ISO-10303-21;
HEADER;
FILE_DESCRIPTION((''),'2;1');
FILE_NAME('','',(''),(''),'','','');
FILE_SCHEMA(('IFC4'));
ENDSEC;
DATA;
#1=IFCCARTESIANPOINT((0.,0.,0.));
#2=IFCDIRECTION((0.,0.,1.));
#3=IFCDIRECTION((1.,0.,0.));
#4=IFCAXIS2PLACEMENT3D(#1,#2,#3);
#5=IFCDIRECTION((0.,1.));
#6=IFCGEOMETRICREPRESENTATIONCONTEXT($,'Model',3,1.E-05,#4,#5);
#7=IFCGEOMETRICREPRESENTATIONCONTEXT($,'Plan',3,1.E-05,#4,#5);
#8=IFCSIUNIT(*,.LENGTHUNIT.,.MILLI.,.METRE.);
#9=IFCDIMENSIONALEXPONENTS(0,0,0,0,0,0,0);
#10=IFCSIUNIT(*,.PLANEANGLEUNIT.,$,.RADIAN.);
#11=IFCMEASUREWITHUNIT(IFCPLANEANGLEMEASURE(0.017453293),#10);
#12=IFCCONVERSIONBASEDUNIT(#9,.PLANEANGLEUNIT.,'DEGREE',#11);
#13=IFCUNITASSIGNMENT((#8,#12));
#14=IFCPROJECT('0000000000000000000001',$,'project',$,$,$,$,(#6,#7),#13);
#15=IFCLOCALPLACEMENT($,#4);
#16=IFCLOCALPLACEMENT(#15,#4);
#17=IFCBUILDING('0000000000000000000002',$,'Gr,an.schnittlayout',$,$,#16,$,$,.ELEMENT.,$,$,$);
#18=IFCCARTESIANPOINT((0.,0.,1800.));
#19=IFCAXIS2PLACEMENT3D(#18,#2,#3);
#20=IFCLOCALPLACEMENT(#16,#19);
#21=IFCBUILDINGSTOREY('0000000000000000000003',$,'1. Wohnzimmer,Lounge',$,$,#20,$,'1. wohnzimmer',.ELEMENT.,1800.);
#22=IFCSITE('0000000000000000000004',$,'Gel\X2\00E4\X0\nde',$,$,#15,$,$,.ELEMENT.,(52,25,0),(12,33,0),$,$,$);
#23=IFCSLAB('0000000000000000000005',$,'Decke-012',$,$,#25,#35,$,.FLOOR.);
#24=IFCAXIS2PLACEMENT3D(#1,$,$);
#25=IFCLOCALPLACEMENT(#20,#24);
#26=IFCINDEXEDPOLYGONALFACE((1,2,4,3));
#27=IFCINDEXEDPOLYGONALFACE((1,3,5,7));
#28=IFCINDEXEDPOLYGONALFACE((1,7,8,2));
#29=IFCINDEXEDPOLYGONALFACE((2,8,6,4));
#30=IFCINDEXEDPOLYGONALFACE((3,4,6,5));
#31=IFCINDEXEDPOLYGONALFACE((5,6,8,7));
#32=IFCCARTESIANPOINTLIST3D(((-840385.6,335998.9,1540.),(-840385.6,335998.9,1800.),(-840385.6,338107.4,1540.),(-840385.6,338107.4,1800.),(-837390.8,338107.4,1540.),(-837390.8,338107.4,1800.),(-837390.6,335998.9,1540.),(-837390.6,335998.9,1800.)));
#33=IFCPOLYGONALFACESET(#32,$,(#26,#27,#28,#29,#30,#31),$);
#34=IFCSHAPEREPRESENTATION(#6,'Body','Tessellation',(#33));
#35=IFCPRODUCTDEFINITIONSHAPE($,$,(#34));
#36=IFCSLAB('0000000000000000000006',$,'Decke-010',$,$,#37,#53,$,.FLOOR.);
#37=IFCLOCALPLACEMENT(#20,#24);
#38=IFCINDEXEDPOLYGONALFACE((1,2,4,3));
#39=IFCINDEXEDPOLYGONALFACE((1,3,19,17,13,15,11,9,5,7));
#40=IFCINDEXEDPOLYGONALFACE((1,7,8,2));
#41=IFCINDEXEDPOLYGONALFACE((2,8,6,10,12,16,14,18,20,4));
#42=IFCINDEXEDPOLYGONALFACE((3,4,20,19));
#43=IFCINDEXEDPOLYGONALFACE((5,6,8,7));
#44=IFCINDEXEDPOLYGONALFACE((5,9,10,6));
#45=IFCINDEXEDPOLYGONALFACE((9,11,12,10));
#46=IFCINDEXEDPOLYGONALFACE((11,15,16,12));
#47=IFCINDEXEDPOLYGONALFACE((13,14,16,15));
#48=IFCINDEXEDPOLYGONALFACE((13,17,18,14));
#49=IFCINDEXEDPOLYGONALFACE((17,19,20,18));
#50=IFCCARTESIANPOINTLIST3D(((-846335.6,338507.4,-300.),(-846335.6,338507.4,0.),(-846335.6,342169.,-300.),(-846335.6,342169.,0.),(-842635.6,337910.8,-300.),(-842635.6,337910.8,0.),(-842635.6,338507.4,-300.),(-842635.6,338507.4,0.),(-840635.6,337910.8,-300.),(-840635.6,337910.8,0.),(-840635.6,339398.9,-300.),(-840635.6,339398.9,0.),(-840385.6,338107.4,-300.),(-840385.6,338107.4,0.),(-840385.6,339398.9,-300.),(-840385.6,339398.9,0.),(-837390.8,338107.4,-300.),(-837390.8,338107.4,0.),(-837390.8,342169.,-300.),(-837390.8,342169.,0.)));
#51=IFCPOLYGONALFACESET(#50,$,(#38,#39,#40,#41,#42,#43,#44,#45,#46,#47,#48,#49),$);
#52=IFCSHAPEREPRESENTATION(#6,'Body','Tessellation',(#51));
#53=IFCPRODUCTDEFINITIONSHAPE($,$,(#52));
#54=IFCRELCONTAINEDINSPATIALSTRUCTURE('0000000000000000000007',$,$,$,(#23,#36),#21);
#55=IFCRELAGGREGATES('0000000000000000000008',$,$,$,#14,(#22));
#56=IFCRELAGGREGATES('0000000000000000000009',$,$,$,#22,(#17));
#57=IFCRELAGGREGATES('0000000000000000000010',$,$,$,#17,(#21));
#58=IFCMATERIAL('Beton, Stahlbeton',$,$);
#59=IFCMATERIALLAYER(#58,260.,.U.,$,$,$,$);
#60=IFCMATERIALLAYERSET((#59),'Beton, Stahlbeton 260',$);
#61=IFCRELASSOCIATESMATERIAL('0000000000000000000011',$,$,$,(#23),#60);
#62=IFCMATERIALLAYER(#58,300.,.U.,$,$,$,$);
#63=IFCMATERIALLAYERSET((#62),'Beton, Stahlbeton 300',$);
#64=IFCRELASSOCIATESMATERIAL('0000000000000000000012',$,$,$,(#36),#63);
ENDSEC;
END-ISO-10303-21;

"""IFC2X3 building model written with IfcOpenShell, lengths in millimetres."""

from ifc_helpers import new_model, entity, si_unit, converted_unit, direction, frame, origin_with_axes, place, context, project, spatial, polyline, outline, extrude, material, layer, layer_set, layer_usage, element, save


model = new_model("IFC2X3")

# Units and contexts
model_context = context("Model", 3, precision=1e-05, world=origin_with_axes(), true_north=direction((0.0, 1.0)))
plan_context = context("Plan", 3, precision=1e-05, world=origin_with_axes(), true_north=direction((0.0, 1.0)))
ifc_project = project(units=[si_unit("LENGTHUNIT", "METRE", prefix="MILLI"), converted_unit("PLANEANGLEUNIT", "DEGREE", entity("IfcPlaneAngleMeasure", 0.017453293), si_unit("PLANEANGLEUNIT", "RADIAN"), dimensions=[0, 0, 0, 0, 0, 0, 0])], contexts=[model_context, plan_context])

# Site, building, storey
site_placement = place(None, origin_with_axes())
site = spatial("IfcSite", under=ifc_project, at=site_placement, Name="Gelände", CompositionType="ELEMENT", RefLatitude=(52, 25, 0), RefLongitude=(12, 33, 0))
building_placement = place(site_placement, origin_with_axes())
building = spatial("IfcBuilding", under=site, at=building_placement, Name="Gr,an.schnittlayout", CompositionType="ELEMENT")
storey_placement = place(building_placement, frame((0.0, 0.0, 1800.0), z_axis=(0.0, 0.0, 1.0), x_axis=(1.0, 0.0, 0.0)))
storey = spatial("IfcBuildingStorey", under=building, at=storey_placement, Name="1. Wohnzimmer,Lounge", LongName="1. wohnzimmer", CompositionType="ELEMENT", Elevation=1800.0)

# Slabs
ifc_material = material(Name="Beton, Stahlbeton")
ifc_layer_1 = layer(ifc_material, 260.0, ventilated="UNKNOWN")
ifc_layer_set_1 = layer_set([ifc_layer_1], Name="Beton, Stahlbeton 260")
ifc_layer_usage_1 = layer_usage(ifc_layer_set_1, "AXIS3", "NEGATIVE", 260.0)
slab_1_placement = place(storey_placement, frame((-840385.7, 338107.4, 1540.0), z_axis=(0.0, 0.0, 1.0), x_axis=(1.0, 0.0, 0.0)))
element("IfcSlab", 1, at=slab_1_placement, inside=storey, material=ifc_layer_usage_1, Name="Decke-012", PredefinedType="FLOOR", context=model_context, shape_type="SweptSolid", body=[
    extrude(outline(polyline([(0.0, 0.0), (2994.9, 0.0), (2995.0, -2108.5), (0.0, -2108.5), (0.0, 0.0)])), origin_with_axes(), (0.0, 0.0, 1.0), 260.0),
])
ifc_layer_2 = layer(ifc_material, 300.0, ventilated="UNKNOWN")
ifc_layer_set_2 = layer_set([ifc_layer_2], Name="Beton, Stahlbeton 300")
ifc_layer_usage_2 = layer_usage(ifc_layer_set_2, "AXIS3", "NEGATIVE", 300.0)
slab_2_placement = place(storey_placement, frame((-837390.8, 338107.4, -300.0), z_axis=(0.0, 0.0, 1.0), x_axis=(-1.0, 0.0, 0.0)))
element("IfcSlab", 2, at=slab_2_placement, inside=storey, material=ifc_layer_usage_2, Name="Decke-010", PredefinedType="FLOOR", context=model_context, shape_type="SweptSolid", body=[
    extrude(outline(polyline([(0.0, 0.0), (2994.9, 0.0), (2994.9, -1291.5), (3244.9, -1291.5), (3244.9, 196.6), (5244.9, 196.6), (5244.9, -400.0), (8944.9, -400.0), (8944.9, -4061.6), (0.0, -4061.6), (0.0, 0.0)])), origin_with_axes(), (0.0, 0.0, 1.0), 300.0),
])

save(model, "model.ifc")
